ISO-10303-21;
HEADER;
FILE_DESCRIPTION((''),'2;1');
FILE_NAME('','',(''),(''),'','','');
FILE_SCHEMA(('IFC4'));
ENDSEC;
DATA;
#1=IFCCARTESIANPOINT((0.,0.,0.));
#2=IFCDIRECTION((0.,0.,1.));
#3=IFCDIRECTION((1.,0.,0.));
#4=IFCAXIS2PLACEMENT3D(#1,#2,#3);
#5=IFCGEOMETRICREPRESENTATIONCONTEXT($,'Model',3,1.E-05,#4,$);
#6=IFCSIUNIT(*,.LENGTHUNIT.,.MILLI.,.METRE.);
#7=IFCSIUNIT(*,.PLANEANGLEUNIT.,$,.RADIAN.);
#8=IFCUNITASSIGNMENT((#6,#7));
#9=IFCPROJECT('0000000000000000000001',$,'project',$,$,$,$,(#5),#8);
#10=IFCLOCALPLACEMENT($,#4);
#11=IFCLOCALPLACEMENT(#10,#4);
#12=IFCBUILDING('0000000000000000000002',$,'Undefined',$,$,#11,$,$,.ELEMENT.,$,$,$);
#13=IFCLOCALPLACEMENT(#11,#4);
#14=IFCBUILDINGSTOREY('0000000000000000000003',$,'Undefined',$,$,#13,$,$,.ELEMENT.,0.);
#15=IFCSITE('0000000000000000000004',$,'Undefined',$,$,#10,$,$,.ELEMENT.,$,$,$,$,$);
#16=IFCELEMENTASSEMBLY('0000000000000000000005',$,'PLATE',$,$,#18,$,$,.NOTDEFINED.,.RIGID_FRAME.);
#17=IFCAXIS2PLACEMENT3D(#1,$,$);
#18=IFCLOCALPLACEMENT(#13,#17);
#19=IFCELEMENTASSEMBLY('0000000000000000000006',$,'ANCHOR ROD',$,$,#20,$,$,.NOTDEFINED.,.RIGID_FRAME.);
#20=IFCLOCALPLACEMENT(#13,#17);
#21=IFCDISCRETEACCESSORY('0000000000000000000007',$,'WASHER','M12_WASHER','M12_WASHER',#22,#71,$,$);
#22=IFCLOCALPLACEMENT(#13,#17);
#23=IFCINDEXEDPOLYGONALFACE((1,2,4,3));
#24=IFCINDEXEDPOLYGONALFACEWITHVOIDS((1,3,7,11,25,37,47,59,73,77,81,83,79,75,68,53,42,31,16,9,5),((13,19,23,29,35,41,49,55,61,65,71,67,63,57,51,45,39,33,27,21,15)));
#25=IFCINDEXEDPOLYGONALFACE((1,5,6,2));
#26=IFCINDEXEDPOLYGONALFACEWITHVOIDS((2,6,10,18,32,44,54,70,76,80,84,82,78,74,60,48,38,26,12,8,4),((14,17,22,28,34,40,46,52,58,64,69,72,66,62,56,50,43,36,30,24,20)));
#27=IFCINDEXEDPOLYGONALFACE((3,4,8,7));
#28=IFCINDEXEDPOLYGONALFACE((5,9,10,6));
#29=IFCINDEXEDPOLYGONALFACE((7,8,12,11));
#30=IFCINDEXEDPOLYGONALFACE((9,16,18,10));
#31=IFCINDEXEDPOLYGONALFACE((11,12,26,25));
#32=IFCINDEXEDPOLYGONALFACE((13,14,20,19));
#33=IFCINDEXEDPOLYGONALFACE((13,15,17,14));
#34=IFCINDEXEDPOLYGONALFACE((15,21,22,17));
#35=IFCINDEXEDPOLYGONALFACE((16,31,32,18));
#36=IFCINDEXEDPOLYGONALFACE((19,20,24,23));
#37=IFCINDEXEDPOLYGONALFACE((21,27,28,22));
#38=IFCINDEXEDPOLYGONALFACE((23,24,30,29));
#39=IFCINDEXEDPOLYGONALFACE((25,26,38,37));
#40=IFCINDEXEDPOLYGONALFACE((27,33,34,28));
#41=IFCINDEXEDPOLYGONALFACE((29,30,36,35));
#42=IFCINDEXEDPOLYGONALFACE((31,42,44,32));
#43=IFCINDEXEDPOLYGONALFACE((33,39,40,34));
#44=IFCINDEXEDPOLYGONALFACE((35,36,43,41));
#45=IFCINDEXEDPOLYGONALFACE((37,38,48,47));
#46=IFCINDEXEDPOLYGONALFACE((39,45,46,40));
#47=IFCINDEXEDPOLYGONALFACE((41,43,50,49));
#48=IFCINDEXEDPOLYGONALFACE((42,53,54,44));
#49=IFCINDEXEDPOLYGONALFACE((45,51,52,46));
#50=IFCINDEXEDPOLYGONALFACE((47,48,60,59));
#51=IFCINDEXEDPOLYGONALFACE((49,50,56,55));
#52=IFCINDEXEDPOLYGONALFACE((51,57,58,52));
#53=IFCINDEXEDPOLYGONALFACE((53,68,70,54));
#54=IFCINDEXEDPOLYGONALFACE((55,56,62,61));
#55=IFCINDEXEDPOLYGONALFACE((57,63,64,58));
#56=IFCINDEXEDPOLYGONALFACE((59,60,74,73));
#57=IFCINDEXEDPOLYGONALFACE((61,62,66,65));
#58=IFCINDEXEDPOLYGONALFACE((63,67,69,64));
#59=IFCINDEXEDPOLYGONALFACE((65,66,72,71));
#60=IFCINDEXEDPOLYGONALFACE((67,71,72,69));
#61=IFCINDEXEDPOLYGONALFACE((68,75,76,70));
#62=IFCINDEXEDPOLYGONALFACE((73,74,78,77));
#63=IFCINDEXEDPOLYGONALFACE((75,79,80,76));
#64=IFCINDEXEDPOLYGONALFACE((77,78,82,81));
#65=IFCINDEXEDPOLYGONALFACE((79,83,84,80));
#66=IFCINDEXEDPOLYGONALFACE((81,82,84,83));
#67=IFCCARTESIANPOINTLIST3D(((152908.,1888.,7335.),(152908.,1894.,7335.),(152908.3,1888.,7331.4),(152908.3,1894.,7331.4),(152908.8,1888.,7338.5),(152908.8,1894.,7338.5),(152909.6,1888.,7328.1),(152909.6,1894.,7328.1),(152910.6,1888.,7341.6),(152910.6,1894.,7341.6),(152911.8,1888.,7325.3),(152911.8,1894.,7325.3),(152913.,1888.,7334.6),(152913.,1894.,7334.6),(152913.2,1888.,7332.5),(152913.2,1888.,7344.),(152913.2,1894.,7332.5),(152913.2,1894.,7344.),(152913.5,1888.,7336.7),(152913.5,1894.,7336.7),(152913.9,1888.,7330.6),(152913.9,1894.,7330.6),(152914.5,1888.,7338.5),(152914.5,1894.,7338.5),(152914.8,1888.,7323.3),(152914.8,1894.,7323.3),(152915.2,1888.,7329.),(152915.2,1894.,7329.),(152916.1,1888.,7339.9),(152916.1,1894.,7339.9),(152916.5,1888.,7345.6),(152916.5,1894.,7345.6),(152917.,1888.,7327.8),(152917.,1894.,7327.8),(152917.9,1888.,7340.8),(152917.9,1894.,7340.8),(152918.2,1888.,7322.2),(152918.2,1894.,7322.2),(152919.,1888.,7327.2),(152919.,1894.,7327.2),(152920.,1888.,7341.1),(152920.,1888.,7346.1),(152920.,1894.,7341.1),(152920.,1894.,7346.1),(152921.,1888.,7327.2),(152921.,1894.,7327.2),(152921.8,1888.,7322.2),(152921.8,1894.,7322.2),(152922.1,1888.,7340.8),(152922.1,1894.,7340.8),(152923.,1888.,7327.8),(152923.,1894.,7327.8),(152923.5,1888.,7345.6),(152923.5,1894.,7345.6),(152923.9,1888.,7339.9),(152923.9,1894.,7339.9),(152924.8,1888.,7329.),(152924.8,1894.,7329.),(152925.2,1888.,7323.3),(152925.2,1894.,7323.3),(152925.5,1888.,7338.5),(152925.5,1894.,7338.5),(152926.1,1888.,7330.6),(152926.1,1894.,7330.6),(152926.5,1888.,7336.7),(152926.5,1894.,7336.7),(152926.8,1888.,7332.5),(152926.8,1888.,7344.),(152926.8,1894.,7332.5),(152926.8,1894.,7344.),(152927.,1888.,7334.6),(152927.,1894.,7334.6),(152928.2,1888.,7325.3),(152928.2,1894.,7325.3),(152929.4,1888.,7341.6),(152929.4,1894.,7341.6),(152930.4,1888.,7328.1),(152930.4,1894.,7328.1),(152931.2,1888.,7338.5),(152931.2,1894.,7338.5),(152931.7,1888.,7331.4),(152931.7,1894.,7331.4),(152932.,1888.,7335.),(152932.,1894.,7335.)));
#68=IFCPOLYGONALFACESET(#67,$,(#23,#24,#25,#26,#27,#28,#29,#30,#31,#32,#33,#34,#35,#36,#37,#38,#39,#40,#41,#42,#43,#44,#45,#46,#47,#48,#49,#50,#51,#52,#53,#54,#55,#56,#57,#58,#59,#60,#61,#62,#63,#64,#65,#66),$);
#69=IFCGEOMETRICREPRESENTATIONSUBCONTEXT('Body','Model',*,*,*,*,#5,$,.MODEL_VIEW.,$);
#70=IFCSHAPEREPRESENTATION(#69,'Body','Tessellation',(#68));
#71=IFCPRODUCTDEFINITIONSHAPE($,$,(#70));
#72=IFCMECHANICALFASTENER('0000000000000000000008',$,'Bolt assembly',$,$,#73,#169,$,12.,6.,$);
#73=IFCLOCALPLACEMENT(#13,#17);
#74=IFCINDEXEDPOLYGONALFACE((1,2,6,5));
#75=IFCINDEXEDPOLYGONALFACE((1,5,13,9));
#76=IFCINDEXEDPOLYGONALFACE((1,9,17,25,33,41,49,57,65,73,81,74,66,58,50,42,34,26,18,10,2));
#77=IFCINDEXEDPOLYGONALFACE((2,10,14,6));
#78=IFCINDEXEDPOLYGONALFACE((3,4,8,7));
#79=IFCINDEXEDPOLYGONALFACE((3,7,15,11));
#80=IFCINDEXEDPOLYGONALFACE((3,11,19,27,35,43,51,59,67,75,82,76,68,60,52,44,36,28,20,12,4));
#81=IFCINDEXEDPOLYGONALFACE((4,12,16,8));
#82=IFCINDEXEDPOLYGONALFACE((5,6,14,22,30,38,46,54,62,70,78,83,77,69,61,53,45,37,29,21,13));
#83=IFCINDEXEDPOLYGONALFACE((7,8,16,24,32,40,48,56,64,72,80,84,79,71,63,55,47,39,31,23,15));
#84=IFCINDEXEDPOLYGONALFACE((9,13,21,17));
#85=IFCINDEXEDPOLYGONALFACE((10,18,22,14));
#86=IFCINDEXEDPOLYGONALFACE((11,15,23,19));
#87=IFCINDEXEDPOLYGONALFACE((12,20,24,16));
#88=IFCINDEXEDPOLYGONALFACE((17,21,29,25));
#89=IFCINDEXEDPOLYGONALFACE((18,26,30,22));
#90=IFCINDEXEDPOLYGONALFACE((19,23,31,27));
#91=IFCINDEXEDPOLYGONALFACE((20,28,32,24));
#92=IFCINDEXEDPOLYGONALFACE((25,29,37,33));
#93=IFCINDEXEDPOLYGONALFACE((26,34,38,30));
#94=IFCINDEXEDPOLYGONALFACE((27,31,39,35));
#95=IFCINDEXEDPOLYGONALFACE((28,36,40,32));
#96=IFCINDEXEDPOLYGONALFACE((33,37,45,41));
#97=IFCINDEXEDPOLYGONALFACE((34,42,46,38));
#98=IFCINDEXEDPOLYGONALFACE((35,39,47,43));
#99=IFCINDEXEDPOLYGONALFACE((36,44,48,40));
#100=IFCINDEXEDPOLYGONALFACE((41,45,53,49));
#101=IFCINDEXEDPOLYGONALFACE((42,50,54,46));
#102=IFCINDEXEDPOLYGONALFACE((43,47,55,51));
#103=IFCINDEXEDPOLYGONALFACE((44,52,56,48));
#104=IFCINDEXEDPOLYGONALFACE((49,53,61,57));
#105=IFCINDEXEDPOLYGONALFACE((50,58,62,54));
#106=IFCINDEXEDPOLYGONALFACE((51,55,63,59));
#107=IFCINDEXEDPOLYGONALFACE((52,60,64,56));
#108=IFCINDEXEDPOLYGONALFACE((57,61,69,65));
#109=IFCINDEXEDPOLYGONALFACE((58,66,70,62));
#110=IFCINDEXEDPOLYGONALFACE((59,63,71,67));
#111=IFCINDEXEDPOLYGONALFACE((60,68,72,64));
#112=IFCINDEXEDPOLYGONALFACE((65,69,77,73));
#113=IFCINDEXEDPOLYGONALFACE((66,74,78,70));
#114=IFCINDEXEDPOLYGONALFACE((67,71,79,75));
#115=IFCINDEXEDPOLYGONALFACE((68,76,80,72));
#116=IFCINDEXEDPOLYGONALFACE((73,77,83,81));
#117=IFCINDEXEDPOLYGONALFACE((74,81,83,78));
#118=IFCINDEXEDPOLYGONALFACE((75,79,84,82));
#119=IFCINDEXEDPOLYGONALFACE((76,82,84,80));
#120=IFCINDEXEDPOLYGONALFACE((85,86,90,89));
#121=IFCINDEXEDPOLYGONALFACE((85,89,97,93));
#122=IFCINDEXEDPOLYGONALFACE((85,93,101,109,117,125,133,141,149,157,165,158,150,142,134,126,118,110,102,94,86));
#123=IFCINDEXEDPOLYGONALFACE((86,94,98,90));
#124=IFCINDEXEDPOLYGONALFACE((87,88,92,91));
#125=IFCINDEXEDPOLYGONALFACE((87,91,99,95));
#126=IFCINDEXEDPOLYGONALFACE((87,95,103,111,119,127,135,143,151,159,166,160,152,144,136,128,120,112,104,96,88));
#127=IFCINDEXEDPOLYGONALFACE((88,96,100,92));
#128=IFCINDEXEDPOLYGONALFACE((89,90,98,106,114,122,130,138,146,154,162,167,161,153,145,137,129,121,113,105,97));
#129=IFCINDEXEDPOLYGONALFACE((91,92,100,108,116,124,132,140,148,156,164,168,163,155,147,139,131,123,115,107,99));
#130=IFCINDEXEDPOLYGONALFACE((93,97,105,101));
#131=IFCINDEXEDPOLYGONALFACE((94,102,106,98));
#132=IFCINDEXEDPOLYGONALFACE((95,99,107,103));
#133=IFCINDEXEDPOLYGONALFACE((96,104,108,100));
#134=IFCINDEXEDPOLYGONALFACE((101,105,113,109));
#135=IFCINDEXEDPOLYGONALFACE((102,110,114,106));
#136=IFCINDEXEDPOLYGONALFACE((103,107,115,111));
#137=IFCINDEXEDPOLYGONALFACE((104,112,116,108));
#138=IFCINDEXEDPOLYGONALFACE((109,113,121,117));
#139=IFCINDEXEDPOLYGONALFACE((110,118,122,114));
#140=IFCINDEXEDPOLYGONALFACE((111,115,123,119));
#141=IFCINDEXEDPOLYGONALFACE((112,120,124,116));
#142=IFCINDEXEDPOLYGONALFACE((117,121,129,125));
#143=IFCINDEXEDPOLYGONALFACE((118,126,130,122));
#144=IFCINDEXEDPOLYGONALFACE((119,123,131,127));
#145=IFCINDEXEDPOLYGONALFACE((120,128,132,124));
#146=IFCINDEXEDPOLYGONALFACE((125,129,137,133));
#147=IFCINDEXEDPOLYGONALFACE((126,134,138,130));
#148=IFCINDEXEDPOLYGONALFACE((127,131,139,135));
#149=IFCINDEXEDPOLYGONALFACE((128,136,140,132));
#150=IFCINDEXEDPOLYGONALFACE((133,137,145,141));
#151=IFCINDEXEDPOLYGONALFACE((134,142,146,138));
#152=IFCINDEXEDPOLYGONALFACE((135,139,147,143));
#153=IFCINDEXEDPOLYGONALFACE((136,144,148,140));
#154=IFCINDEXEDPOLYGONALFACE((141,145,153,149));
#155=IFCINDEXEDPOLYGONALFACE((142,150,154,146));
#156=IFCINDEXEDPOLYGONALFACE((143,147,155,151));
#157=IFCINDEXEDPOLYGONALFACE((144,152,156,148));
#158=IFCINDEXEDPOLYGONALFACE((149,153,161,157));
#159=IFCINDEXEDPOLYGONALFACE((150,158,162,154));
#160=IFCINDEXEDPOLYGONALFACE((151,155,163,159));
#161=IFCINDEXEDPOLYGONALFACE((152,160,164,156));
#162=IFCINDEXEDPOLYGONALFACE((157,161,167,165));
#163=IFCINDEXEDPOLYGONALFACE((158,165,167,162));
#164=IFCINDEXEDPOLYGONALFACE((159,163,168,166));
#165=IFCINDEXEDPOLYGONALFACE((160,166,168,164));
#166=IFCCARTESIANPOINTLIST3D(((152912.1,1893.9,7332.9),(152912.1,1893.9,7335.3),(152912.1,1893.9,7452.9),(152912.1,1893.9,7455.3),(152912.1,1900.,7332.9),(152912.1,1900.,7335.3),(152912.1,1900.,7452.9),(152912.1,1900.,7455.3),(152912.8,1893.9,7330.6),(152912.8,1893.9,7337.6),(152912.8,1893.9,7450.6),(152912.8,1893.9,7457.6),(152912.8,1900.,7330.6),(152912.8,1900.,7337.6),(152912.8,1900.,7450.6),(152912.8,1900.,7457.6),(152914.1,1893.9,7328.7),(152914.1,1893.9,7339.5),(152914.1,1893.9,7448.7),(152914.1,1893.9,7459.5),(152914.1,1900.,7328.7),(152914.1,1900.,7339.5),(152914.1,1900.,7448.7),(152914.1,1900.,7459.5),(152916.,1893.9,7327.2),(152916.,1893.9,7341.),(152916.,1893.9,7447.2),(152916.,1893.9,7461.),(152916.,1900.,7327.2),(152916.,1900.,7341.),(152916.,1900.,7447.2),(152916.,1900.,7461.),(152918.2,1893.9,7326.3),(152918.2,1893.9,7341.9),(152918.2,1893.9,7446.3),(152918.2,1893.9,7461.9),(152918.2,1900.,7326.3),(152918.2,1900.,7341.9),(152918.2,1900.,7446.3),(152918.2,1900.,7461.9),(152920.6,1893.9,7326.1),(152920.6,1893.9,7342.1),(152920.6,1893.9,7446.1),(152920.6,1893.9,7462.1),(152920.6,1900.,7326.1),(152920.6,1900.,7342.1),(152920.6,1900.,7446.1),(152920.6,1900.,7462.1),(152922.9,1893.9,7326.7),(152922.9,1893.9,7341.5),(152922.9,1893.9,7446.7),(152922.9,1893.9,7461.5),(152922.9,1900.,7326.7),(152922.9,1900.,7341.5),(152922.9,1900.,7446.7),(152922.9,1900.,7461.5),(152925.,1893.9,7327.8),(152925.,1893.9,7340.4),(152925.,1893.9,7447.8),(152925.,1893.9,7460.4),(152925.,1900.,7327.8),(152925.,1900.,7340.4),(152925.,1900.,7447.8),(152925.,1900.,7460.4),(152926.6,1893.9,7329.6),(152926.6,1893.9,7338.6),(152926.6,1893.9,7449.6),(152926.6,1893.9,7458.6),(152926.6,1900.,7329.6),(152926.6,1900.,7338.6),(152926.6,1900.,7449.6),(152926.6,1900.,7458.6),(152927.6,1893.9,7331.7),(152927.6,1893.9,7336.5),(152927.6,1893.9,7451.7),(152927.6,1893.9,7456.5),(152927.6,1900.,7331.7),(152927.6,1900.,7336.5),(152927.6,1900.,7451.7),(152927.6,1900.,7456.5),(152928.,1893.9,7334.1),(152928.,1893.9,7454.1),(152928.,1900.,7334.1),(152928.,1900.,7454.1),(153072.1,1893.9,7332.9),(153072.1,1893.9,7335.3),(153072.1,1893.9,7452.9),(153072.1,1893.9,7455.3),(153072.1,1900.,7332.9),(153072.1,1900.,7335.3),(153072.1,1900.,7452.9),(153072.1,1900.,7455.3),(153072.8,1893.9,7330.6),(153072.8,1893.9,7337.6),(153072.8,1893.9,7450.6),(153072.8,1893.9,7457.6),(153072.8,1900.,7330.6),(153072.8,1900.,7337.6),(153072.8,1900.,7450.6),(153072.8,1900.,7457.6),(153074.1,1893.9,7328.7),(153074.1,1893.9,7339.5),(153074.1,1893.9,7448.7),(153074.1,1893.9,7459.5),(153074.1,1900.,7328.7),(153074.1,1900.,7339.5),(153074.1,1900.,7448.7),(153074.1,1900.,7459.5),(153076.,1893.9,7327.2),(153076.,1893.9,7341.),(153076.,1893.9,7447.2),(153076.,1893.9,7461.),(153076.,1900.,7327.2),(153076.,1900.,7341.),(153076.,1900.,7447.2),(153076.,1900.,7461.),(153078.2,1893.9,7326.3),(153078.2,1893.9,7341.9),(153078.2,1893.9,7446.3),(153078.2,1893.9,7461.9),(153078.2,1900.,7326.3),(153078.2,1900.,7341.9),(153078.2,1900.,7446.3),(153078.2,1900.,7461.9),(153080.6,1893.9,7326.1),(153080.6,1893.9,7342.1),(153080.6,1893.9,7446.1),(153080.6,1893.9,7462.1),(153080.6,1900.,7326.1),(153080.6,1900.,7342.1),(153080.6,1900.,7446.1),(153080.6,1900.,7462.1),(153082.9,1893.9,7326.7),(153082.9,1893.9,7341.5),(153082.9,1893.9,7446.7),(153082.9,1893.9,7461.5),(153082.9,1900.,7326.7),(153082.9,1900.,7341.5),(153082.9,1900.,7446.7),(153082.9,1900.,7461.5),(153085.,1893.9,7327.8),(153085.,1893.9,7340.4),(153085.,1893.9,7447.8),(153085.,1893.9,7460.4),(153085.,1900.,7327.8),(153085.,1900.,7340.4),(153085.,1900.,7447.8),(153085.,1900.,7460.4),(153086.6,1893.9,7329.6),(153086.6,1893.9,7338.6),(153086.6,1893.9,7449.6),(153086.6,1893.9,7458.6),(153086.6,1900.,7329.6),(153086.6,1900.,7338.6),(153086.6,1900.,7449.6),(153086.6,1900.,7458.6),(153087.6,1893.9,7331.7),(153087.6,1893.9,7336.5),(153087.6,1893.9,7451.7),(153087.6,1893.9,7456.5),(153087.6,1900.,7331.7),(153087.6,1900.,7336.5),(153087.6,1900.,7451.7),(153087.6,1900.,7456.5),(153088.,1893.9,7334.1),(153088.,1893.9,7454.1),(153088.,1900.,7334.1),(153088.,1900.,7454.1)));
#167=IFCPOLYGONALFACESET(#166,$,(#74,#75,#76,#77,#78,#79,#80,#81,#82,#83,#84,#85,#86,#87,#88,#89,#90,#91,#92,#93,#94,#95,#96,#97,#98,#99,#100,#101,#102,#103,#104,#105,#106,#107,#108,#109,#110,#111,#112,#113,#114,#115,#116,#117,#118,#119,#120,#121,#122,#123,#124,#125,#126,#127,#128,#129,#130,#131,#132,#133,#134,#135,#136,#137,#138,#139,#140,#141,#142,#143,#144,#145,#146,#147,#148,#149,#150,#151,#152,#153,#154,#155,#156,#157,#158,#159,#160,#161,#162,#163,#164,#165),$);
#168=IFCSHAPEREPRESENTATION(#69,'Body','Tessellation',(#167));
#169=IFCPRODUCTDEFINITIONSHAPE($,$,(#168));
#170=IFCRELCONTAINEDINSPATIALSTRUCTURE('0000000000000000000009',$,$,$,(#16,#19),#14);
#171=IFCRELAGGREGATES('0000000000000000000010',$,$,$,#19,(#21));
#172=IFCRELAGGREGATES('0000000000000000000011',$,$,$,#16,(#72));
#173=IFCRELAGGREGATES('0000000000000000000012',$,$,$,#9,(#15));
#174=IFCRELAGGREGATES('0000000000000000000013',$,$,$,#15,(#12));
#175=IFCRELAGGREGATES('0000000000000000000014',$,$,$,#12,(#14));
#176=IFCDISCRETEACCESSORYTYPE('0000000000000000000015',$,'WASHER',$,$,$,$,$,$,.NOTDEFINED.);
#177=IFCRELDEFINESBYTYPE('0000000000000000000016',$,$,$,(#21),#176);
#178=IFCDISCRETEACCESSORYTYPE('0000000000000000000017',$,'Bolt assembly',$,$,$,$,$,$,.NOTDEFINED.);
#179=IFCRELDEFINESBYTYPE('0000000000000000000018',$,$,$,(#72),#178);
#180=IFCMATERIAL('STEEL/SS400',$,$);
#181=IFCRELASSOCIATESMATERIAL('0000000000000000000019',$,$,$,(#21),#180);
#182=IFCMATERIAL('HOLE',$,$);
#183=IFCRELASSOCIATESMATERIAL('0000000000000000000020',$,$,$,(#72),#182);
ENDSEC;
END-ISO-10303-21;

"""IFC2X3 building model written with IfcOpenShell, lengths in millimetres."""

from ifc_helpers import new_model, si_unit, frame, origin_with_axes, origin_2d_with_axis, place, context, subcontext, project, spatial, circle, hollow_circle, extrude, source, transform, mapped, material, type_object, element, aggregate, save


model = new_model("IFC2X3")

# Units and contexts
model_context = context("Model", 3, precision=1e-05, world=origin_with_axes())
body_context = subcontext(model_context, "Body", "Model", "MODEL_VIEW")
ifc_project = project(units=[si_unit("LENGTHUNIT", "METRE", prefix="MILLI"), si_unit("PLANEANGLEUNIT", "RADIAN")], contexts=[model_context])

# Site, building, storey
site_placement = place(None, origin_with_axes())
site = spatial("IfcSite", under=ifc_project, at=site_placement, Name="Undefined", CompositionType="ELEMENT")
building_placement = place(site_placement, origin_with_axes())
building = spatial("IfcBuilding", under=site, at=building_placement, Name="Undefined", CompositionType="ELEMENT")
storey_placement = place(building_placement, origin_with_axes())
storey = spatial("IfcBuildingStorey", under=building, at=storey_placement, Name="Undefined", CompositionType="ELEMENT", Elevation=0.0)

# Shared definitions
ifc_material_1 = material(Name="STEEL/SS400")

# Element assembly
assembly_1_placement = place(storey_placement, origin_with_axes())
assembly_1 = element("IfcElementAssembly", 1, at=assembly_1_placement, inside=storey, Name="PLATE", AssemblyPlace="NOTDEFINED", PredefinedType="RIGID_FRAME")

# Shared definitions
ifc_material_2 = material(Name="HOLE")
discrete_accessory_type_1 = type_object("IfcDiscreteAccessoryType", Name="Bolt assembly")

# Element assembly, discrete accessory
discrete_accessory_type_2 = type_object("IfcDiscreteAccessoryType", Name="WASHER")
assembly_2_placement = place(storey_placement, origin_with_axes())
assembly_2 = element("IfcElementAssembly", 2, at=assembly_2_placement, inside=storey, Name="ANCHOR ROD", AssemblyPlace="NOTDEFINED", PredefinedType="RIGID_FRAME")
discrete_accessory_1_placement = place(assembly_2_placement, frame((152920.0, 1888.0, 7334.1), z_axis=(-1.0, 0.0, 0.0), x_axis=(0.0, 1.0, 0.0)))
discrete_accessory_1 = element("IfcDiscreteAccessory", 3, at=discrete_accessory_1_placement, type_object=discrete_accessory_type_2, material=ifc_material_1, Name="WASHER", Description="M12_WASHER", ObjectType="M12_WASHER", context=body_context, shape_type="SweptSolid", body=[
    extrude(hollow_circle(Radius=12.0, WallThickness=5.0, at=origin_2d_with_axis()), frame((6.0, 0.0, 0.0), z_axis=(-1.0, 0.0, 0.0), x_axis=(0.0, -1.0, 0.0)), (0.0, 0.0, 1.0), 6.0),
])
aggregate(assembly_2, [discrete_accessory_1])

# Mechanical fastener
shared_shape_1 = source(origin_with_axes(), body_context, "Body", "SweptSolid", [
    extrude(circle(Radius=8.0, at=origin_2d_with_axis()), frame((0.0, -6.0, 0.0), z_axis=(0.0, 1.0, 0.0), x_axis=(1.0, 0.0, 0.0)), (0.0, 0.0, 1.0), 6.1),
])
mechanical_fastener_1_placement = place(assembly_1_placement, frame((152930.0, 1894.0, 7394.1), z_axis=(0.0, 0.0, -1.0), x_axis=(1.0, 0.0, 0.0)))
mechanical_fastener_1 = element("IfcMechanicalFastener", 4, at=mechanical_fastener_1_placement, type_object=discrete_accessory_type_1, material=ifc_material_2, Name="Bolt assembly", NominalDiameter=12.0, NominalLength=6.0, context=body_context, shape_type="MappedRepresentation", body=[
    mapped(shared_shape_1, transform((-10.0, 0.0, -60.0))),
    mapped(shared_shape_1, transform((150.0, 0.0, -60.0))),
    mapped(shared_shape_1, transform((-10.0, 0.0, 60.0))),
    mapped(shared_shape_1, transform((150.0, 0.0, 60.0))),
])
aggregate(assembly_1, [mechanical_fastener_1])

save(model, "model.ifc")
